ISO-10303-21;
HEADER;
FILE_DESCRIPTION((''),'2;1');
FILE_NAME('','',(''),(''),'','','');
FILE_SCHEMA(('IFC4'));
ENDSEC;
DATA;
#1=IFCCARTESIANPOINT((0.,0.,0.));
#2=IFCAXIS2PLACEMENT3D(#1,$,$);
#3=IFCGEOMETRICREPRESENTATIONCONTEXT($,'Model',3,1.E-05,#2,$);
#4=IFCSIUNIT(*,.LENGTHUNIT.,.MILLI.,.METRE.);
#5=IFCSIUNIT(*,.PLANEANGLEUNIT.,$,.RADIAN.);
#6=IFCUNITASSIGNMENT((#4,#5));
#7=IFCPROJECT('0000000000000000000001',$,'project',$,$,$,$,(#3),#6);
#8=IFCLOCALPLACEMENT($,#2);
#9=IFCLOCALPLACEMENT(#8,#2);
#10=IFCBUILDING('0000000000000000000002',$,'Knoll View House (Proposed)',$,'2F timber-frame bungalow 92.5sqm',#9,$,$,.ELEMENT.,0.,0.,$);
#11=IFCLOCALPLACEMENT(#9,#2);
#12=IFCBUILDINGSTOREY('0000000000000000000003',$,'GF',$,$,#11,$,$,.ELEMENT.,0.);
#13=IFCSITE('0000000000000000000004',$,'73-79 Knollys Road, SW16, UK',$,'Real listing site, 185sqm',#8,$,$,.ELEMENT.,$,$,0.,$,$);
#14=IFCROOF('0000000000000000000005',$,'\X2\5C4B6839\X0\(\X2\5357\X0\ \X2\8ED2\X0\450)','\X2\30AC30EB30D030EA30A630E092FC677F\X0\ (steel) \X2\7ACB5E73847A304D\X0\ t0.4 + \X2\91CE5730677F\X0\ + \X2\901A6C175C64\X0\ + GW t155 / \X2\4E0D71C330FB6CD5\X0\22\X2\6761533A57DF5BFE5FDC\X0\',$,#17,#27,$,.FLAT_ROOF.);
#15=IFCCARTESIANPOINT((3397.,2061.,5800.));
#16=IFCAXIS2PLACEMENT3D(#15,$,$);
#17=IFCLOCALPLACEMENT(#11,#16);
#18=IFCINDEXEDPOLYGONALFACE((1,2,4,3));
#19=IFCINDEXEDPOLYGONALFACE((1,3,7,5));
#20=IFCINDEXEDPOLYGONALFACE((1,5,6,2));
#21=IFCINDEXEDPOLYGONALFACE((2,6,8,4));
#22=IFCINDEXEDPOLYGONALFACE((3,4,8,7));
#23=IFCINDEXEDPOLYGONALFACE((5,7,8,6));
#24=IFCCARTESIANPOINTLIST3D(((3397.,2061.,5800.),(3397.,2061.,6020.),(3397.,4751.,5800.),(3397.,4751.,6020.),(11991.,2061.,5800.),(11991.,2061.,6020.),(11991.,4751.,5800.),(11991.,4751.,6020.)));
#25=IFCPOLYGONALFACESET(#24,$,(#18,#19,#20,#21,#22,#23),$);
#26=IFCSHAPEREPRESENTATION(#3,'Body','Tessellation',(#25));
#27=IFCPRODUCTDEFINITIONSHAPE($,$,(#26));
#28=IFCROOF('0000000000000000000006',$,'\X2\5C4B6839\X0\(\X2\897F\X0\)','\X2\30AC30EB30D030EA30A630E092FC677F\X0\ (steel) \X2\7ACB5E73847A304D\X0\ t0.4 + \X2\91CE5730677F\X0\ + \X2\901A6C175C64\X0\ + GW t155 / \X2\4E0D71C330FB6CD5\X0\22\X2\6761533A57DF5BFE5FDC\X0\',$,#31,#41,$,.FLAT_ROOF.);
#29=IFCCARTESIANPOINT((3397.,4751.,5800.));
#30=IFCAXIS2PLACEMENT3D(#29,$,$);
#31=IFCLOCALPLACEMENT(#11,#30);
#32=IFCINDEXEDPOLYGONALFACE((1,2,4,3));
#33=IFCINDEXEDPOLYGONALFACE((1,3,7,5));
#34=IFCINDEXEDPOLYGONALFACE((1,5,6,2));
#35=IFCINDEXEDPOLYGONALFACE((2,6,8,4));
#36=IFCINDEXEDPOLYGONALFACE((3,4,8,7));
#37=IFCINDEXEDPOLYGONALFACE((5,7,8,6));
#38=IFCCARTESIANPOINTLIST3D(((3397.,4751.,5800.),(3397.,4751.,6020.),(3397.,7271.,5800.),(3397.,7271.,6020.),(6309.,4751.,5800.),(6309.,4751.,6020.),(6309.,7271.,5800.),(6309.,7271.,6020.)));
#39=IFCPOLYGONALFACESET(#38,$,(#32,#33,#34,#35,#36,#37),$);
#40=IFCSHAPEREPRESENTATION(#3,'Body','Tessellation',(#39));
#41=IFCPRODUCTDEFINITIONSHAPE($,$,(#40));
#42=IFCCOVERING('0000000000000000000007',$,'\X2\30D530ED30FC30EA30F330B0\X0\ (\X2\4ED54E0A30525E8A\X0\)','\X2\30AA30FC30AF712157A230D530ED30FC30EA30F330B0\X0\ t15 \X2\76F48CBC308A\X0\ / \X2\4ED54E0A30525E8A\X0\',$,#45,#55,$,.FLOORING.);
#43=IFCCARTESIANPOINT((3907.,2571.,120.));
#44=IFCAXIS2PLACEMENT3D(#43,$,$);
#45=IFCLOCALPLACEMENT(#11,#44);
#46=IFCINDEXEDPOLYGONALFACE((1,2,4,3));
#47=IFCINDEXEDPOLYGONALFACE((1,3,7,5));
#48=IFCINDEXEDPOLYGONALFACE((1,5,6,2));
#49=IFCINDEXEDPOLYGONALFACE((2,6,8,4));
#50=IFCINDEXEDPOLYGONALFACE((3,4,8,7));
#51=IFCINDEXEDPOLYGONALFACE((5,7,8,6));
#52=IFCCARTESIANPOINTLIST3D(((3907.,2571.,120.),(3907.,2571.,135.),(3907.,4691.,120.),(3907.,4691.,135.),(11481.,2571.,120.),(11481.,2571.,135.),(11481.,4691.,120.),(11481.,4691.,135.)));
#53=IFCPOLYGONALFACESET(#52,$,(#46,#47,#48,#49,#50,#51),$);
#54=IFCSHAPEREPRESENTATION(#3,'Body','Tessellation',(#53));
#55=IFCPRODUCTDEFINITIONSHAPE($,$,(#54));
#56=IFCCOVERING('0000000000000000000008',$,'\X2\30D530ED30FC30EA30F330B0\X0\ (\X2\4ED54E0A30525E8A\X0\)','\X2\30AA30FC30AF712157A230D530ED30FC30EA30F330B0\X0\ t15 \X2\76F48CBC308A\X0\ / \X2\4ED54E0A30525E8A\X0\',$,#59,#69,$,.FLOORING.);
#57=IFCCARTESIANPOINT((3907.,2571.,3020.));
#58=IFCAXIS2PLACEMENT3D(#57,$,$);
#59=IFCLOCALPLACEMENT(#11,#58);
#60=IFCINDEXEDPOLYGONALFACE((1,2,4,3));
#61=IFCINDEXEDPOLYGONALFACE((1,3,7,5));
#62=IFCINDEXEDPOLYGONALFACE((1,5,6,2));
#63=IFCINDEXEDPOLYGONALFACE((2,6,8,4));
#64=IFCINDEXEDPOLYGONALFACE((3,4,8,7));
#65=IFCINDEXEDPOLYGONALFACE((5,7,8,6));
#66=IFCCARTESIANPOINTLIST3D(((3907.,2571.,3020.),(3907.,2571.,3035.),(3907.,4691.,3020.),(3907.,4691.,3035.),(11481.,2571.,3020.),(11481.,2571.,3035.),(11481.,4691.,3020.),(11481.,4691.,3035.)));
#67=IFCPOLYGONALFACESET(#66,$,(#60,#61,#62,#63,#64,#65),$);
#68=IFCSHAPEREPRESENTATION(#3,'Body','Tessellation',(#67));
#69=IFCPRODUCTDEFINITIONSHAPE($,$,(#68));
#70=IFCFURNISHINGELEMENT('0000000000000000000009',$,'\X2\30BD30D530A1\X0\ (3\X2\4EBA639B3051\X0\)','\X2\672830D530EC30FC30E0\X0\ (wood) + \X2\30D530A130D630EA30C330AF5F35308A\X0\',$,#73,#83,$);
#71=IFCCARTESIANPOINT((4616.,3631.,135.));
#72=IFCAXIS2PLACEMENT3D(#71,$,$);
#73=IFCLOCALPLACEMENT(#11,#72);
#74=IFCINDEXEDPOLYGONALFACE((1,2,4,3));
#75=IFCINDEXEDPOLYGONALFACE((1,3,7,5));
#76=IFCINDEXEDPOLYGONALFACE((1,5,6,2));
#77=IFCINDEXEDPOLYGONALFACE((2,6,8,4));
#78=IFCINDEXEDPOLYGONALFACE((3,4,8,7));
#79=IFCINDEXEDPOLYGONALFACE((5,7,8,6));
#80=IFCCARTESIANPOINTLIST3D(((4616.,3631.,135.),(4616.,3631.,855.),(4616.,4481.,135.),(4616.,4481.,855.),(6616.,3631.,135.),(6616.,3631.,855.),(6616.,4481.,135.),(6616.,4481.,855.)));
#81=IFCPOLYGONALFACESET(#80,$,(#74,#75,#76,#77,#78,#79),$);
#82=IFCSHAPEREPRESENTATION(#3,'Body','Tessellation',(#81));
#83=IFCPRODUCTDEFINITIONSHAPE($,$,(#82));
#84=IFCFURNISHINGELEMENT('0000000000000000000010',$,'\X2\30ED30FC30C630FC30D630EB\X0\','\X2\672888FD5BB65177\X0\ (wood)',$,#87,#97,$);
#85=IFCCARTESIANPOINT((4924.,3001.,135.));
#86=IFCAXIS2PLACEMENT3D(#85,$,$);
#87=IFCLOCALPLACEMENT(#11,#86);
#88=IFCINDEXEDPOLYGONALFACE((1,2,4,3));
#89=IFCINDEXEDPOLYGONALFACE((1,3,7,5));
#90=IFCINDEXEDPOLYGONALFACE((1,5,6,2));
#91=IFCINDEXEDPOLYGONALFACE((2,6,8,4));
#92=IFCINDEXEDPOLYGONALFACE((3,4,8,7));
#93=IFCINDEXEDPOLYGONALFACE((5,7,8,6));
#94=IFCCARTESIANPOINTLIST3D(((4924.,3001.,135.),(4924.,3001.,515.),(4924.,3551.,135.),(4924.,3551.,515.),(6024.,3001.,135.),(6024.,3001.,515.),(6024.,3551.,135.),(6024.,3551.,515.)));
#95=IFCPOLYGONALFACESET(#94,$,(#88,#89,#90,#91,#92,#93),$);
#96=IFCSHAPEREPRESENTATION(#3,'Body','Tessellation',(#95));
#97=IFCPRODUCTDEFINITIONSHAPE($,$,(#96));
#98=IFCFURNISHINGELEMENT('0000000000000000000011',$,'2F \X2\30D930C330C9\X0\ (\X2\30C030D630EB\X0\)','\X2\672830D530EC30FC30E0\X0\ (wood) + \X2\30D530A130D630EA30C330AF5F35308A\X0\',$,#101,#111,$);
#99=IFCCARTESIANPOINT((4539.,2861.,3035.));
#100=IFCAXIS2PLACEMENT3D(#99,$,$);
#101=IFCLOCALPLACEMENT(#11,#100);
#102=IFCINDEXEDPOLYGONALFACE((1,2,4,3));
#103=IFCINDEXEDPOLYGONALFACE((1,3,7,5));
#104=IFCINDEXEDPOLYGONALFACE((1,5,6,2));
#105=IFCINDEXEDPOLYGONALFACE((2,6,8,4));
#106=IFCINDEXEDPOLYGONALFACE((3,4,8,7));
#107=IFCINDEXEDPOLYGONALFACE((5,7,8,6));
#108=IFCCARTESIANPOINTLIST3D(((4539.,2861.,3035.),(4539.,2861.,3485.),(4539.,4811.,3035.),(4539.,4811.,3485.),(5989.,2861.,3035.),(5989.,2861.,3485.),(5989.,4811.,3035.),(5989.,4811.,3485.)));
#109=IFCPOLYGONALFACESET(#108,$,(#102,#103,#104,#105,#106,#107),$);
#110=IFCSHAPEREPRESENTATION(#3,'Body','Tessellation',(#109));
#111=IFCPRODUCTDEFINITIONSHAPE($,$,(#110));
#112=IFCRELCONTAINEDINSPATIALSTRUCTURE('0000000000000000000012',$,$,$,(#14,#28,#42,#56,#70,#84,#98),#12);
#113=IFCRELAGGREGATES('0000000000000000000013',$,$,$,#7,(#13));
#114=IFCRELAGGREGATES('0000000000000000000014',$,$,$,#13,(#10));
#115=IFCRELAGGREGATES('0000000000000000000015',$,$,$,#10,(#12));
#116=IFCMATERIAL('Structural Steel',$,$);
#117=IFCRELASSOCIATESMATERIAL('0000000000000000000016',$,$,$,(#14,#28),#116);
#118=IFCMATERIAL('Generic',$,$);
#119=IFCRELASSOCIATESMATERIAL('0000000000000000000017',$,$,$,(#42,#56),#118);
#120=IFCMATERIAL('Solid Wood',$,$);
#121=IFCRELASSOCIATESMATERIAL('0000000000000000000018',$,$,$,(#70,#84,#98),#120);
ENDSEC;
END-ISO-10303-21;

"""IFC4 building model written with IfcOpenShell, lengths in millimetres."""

from ifc_helpers import new_model, si_unit, frame, frame_2d, origin, place, context, project, spatial, rectangle, extrude, material, element, save


model = new_model("IFC4")

# Units and contexts
model_context = context("Model", 3, precision=1e-05, world=origin())
ifc_project = project(units=[si_unit("LENGTHUNIT", "METRE", prefix="MILLI"), si_unit("PLANEANGLEUNIT", "RADIAN")], contexts=[model_context])

# Site, building, storey
site_placement = place(None, origin())
site = spatial("IfcSite", under=ifc_project, at=site_placement, Name="73-79 Knollys Road, SW16, UK", ObjectType="Real listing site, 185sqm", CompositionType="ELEMENT", RefElevation=0.0)
building_placement = place(site_placement, origin())
building = spatial("IfcBuilding", under=site, at=building_placement, Name="Knoll View House (Proposed)", ObjectType="2F timber-frame bungalow 92.5sqm", CompositionType="ELEMENT", ElevationOfRefHeight=0.0, ElevationOfTerrain=0.0)
storey_placement = place(building_placement, origin())
storey = spatial("IfcBuildingStorey", under=building, at=storey_placement, Name="GF", CompositionType="ELEMENT", Elevation=0.0)

# Shared definitions
ifc_material_1 = material(Name="Solid Wood")

# Roofs
ifc_material_2 = material(Name="Structural Steel")
roof_1_placement = place(storey_placement, frame((3397.0, 2061.0, 5800.0)))
element("IfcRoof", 1, at=roof_1_placement, inside=storey, material=ifc_material_2, Name="屋根(南 軒450)", Description="ガルバリウム鋼板 (steel) 立平葺き t0.4 + 野地板 + 通気層 + GW t155 / 不燃・法22条区域対応", PredefinedType="FLAT_ROOF", context=model_context, shape_type="SweptSolid", body=[
    extrude(rectangle(XDim=8594.0, YDim=2690.0, at=frame_2d((4297.0, 1345.0))), frame((3397.0, 2061.0, 5800.0)), (0.0, 0.0, 1.0), 220.0),
])
roof_2_placement = place(storey_placement, frame((3397.0, 4751.0, 5800.0)))
element("IfcRoof", 2, at=roof_2_placement, inside=storey, material=ifc_material_2, Name="屋根(西)", Description="ガルバリウム鋼板 (steel) 立平葺き t0.4 + 野地板 + 通気層 + GW t155 / 不燃・法22条区域対応", PredefinedType="FLAT_ROOF", context=model_context, shape_type="SweptSolid", body=[
    extrude(rectangle(XDim=2912.0, YDim=2520.0, at=frame_2d((1456.0, 1260.0))), frame((3397.0, 4751.0, 5800.0)), (0.0, 0.0, 1.0), 220.0),
])

# Coverings
ifc_material_3 = material(Name="Generic")
covering_1_placement = place(storey_placement, frame((3907.0, 2571.0, 120.0)))
element("IfcCovering", 3, at=covering_1_placement, inside=storey, material=ifc_material_3, Name="フローリング (仕上げ床)", Description="オーク無垢フローリング t15 直貼り / 仕上げ床", PredefinedType="FLOORING", context=model_context, shape_type="SweptSolid", body=[
    extrude(rectangle(XDim=7574.0, YDim=2120.0, at=frame_2d((3787.0, 1060.0))), frame((3907.0, 2571.0, 120.0)), (0.0, 0.0, 1.0), 15.0),
])
covering_2_placement = place(storey_placement, frame((3907.0, 2571.0, 3020.0)))
element("IfcCovering", 4, at=covering_2_placement, inside=storey, material=ifc_material_3, Name="フローリング (仕上げ床)", Description="オーク無垢フローリング t15 直貼り / 仕上げ床", PredefinedType="FLOORING", context=model_context, shape_type="SweptSolid", body=[
    extrude(rectangle(XDim=7574.0, YDim=2120.0, at=frame_2d((3787.0, 1060.0))), frame((3907.0, 2571.0, 3020.0)), (0.0, 0.0, 1.0), 15.0),
])

# Furnishing elements
furnishing_1_placement = place(storey_placement, frame((4616.0, 3631.0, 135.0)))
element("IfcFurnishingElement", 5, at=furnishing_1_placement, inside=storey, material=ifc_material_1, Name="ソファ (3人掛け)", Description="木フレーム (wood) + ファブリック張り", context=model_context, shape_type="SweptSolid", body=[
    extrude(rectangle(XDim=2000.0, YDim=850.0, at=frame_2d((1000.0, 425.0))), frame((4616.0, 3631.0, 135.0)), (0.0, 0.0, 1.0), 720.0),
])
furnishing_2_placement = place(storey_placement, frame((4924.0, 3001.0, 135.0)))
element("IfcFurnishingElement", 6, at=furnishing_2_placement, inside=storey, material=ifc_material_1, Name="ローテーブル", Description="木製家具 (wood)", context=model_context, shape_type="SweptSolid", body=[
    extrude(rectangle(XDim=1100.0, YDim=550.0, at=frame_2d((550.0, 275.0))), frame((4924.0, 3001.0, 135.0)), (0.0, 0.0, 1.0), 380.0),
])
furnishing_3_placement = place(storey_placement, frame((4539.0, 2861.0, 3035.0)))
element("IfcFurnishingElement", 7, at=furnishing_3_placement, inside=storey, material=ifc_material_1, Name="2F ベッド (ダブル)", Description="木フレーム (wood) + ファブリック張り", context=model_context, shape_type="SweptSolid", body=[
    extrude(rectangle(XDim=1450.0, YDim=1950.0, at=frame_2d((725.0, 975.0))), frame((4539.0, 2861.0, 3035.0)), (0.0, 0.0, 1.0), 450.0),
])

save(model, "model.ifc")
